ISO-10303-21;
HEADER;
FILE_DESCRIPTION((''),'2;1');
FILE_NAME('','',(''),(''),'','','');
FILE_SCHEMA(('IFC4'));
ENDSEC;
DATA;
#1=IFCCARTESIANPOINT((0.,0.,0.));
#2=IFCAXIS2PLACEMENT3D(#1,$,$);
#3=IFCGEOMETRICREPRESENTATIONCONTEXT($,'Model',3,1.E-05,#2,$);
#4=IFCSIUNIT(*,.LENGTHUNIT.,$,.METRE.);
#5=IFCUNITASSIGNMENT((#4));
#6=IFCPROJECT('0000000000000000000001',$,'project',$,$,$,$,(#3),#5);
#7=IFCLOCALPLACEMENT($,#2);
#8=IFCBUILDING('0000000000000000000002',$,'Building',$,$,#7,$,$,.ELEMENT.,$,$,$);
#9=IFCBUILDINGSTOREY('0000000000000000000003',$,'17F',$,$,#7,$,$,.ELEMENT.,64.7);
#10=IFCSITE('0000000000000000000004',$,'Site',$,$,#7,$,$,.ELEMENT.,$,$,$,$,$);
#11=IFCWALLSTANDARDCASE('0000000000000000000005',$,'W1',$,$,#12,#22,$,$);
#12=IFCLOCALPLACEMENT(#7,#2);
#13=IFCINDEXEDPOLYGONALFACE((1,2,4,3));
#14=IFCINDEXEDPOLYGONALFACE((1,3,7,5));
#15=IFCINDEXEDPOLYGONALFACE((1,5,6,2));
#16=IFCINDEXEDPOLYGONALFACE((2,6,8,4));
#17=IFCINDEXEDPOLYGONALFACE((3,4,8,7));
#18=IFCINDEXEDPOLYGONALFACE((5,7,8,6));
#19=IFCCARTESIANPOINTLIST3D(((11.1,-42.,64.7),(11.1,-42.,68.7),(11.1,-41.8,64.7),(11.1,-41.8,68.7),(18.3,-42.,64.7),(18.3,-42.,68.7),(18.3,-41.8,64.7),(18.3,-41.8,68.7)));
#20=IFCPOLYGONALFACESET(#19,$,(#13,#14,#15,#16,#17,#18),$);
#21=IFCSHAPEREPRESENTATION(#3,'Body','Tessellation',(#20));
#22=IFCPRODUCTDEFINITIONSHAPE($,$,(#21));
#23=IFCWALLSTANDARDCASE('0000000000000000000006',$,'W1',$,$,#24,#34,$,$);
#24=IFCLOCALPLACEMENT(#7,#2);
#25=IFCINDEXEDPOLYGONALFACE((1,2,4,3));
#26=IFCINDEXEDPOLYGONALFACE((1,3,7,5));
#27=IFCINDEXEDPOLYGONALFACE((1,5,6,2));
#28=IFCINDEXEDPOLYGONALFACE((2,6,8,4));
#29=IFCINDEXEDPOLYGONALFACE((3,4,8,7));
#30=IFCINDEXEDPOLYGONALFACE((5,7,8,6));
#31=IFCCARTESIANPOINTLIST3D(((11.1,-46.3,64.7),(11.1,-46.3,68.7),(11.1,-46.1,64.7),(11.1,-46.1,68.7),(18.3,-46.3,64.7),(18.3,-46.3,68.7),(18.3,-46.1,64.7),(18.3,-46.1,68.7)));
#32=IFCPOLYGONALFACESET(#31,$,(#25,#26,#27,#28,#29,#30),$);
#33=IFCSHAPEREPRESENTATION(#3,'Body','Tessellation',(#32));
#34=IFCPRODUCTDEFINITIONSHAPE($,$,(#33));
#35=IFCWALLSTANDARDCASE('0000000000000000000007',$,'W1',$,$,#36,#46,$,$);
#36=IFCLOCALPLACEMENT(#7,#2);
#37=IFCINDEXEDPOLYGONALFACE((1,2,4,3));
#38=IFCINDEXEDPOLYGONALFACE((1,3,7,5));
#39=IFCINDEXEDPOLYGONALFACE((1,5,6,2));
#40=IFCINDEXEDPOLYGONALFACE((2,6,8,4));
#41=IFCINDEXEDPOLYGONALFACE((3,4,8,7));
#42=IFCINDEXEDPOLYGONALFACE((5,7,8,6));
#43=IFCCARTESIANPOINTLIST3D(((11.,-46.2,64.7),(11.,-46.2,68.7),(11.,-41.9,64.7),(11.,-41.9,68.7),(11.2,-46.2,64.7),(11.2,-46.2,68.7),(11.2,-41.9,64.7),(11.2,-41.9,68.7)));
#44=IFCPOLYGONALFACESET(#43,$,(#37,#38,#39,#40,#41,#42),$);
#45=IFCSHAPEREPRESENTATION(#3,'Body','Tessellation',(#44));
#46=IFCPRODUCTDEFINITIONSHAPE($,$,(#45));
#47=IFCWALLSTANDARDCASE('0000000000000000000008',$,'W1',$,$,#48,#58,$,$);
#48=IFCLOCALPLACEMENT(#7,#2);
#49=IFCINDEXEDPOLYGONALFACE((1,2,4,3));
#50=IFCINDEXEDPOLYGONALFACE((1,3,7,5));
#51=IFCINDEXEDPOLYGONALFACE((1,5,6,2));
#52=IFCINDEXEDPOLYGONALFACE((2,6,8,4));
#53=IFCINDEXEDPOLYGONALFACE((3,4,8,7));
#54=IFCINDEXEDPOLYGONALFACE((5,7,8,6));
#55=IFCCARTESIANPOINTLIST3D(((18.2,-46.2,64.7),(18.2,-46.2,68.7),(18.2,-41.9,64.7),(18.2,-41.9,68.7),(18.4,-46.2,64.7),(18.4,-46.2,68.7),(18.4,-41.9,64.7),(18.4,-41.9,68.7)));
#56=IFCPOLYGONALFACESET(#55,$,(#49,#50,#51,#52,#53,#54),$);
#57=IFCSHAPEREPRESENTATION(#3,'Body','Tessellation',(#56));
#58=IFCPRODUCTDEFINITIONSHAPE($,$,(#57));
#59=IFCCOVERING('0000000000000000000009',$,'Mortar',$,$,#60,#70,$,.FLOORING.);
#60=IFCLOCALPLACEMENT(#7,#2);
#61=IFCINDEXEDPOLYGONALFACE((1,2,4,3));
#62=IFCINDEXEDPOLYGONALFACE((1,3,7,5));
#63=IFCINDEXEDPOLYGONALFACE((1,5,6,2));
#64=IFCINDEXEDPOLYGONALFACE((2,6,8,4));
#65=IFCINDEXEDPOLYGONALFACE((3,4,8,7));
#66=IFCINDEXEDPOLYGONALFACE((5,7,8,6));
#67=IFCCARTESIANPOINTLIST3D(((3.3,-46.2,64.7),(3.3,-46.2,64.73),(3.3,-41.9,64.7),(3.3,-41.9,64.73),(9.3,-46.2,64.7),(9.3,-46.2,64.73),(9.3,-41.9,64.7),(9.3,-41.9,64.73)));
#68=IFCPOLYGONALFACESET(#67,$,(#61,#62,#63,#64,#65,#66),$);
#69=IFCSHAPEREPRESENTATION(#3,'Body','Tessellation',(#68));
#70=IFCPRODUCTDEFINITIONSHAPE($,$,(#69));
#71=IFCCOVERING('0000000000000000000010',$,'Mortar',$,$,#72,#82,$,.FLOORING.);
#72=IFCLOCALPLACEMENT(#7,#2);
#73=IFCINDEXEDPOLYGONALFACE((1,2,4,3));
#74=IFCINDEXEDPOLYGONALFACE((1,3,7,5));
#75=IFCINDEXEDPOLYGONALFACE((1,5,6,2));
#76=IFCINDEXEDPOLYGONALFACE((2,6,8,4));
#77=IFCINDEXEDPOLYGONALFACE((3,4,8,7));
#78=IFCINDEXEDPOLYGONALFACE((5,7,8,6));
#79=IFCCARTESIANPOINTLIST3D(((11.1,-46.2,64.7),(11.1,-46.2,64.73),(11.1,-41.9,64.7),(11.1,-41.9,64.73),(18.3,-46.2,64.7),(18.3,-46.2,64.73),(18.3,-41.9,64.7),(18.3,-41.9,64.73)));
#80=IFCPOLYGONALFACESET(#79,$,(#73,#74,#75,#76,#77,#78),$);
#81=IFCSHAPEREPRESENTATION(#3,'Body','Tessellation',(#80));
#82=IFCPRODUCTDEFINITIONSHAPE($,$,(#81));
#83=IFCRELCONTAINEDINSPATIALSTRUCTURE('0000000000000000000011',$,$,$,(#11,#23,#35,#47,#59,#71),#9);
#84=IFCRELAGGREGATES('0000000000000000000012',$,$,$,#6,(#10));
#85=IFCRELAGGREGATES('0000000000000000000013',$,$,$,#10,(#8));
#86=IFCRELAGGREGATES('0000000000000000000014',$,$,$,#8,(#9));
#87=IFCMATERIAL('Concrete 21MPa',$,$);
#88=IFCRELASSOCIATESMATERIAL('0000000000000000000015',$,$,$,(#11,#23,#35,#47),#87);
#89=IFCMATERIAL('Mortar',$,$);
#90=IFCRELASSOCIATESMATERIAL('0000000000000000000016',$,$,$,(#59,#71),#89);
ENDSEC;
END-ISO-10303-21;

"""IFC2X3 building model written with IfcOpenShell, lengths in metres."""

from ifc_helpers import new_model, si_unit, frame, origin, origin_2d, place, context, project, spatial, rectangle, extrude, material, element, save


model = new_model("IFC2X3")

# Units and contexts
model_context = context("Model", 3, precision=1e-05, world=origin())
ifc_project = project(units=[si_unit("LENGTHUNIT", "METRE")], contexts=[model_context])

# Site, building, storey
placement = place(None, origin())
site = spatial("IfcSite", under=ifc_project, at=placement, Name="Site", CompositionType="ELEMENT")
building = spatial("IfcBuilding", under=site, at=placement, Name="Building", CompositionType="ELEMENT")
storey = spatial("IfcBuildingStorey", under=building, at=placement, Name="17F", CompositionType="ELEMENT", Elevation=64.7)

# Shared definitions
ifc_material_1 = material(Name="Concrete 21MPa")

# Walls
for number, where, name in (
    (1, (14.7, -41.9, 64.7), "W1"),
    (2, (14.7, -46.2, 64.7), "W1"),
):
    element("IfcWallStandardCase", number, at=place(None, frame(where)), inside=storey, material=ifc_material_1, Name=name, context=model_context, shape_type="SweptSolid", body=[
        extrude(rectangle(XDim=7.2, YDim=0.2, at=origin_2d()), origin(), (0.0, 0.0, 1.0), 4.0),
    ])
for number, where, name in (
    (3, (11.1, -44.05, 64.7), "W1"),
    (4, (18.3, -44.05, 64.7), "W1"),
):
    element("IfcWallStandardCase", number, at=place(None, frame(where)), inside=storey, material=ifc_material_1, Name=name, context=model_context, shape_type="SweptSolid", body=[
        extrude(rectangle(XDim=0.2, YDim=4.3, at=origin_2d()), origin(), (0.0, 0.0, 1.0), 4.0),
    ])

# Coverings
ifc_material_2 = material(Name="Mortar")
covering_1_placement = place(None, frame((6.3, -44.05, 64.7)))
element("IfcCovering", 5, at=covering_1_placement, inside=storey, material=ifc_material_2, Name="Mortar", PredefinedType="FLOORING", context=model_context, shape_type="SweptSolid", body=[
    extrude(rectangle(XDim=6.0, YDim=4.3, at=origin_2d()), origin(), (0.0, 0.0, 1.0), 0.03),
])
covering_2_placement = place(None, frame((14.7, -44.05, 64.7)))
element("IfcCovering", 6, at=covering_2_placement, inside=storey, material=ifc_material_2, Name="Mortar", PredefinedType="FLOORING", context=model_context, shape_type="SweptSolid", body=[
    extrude(rectangle(XDim=7.2, YDim=4.3, at=origin_2d()), origin(), (0.0, 0.0, 1.0), 0.03),
])

save(model, "model.ifc")
